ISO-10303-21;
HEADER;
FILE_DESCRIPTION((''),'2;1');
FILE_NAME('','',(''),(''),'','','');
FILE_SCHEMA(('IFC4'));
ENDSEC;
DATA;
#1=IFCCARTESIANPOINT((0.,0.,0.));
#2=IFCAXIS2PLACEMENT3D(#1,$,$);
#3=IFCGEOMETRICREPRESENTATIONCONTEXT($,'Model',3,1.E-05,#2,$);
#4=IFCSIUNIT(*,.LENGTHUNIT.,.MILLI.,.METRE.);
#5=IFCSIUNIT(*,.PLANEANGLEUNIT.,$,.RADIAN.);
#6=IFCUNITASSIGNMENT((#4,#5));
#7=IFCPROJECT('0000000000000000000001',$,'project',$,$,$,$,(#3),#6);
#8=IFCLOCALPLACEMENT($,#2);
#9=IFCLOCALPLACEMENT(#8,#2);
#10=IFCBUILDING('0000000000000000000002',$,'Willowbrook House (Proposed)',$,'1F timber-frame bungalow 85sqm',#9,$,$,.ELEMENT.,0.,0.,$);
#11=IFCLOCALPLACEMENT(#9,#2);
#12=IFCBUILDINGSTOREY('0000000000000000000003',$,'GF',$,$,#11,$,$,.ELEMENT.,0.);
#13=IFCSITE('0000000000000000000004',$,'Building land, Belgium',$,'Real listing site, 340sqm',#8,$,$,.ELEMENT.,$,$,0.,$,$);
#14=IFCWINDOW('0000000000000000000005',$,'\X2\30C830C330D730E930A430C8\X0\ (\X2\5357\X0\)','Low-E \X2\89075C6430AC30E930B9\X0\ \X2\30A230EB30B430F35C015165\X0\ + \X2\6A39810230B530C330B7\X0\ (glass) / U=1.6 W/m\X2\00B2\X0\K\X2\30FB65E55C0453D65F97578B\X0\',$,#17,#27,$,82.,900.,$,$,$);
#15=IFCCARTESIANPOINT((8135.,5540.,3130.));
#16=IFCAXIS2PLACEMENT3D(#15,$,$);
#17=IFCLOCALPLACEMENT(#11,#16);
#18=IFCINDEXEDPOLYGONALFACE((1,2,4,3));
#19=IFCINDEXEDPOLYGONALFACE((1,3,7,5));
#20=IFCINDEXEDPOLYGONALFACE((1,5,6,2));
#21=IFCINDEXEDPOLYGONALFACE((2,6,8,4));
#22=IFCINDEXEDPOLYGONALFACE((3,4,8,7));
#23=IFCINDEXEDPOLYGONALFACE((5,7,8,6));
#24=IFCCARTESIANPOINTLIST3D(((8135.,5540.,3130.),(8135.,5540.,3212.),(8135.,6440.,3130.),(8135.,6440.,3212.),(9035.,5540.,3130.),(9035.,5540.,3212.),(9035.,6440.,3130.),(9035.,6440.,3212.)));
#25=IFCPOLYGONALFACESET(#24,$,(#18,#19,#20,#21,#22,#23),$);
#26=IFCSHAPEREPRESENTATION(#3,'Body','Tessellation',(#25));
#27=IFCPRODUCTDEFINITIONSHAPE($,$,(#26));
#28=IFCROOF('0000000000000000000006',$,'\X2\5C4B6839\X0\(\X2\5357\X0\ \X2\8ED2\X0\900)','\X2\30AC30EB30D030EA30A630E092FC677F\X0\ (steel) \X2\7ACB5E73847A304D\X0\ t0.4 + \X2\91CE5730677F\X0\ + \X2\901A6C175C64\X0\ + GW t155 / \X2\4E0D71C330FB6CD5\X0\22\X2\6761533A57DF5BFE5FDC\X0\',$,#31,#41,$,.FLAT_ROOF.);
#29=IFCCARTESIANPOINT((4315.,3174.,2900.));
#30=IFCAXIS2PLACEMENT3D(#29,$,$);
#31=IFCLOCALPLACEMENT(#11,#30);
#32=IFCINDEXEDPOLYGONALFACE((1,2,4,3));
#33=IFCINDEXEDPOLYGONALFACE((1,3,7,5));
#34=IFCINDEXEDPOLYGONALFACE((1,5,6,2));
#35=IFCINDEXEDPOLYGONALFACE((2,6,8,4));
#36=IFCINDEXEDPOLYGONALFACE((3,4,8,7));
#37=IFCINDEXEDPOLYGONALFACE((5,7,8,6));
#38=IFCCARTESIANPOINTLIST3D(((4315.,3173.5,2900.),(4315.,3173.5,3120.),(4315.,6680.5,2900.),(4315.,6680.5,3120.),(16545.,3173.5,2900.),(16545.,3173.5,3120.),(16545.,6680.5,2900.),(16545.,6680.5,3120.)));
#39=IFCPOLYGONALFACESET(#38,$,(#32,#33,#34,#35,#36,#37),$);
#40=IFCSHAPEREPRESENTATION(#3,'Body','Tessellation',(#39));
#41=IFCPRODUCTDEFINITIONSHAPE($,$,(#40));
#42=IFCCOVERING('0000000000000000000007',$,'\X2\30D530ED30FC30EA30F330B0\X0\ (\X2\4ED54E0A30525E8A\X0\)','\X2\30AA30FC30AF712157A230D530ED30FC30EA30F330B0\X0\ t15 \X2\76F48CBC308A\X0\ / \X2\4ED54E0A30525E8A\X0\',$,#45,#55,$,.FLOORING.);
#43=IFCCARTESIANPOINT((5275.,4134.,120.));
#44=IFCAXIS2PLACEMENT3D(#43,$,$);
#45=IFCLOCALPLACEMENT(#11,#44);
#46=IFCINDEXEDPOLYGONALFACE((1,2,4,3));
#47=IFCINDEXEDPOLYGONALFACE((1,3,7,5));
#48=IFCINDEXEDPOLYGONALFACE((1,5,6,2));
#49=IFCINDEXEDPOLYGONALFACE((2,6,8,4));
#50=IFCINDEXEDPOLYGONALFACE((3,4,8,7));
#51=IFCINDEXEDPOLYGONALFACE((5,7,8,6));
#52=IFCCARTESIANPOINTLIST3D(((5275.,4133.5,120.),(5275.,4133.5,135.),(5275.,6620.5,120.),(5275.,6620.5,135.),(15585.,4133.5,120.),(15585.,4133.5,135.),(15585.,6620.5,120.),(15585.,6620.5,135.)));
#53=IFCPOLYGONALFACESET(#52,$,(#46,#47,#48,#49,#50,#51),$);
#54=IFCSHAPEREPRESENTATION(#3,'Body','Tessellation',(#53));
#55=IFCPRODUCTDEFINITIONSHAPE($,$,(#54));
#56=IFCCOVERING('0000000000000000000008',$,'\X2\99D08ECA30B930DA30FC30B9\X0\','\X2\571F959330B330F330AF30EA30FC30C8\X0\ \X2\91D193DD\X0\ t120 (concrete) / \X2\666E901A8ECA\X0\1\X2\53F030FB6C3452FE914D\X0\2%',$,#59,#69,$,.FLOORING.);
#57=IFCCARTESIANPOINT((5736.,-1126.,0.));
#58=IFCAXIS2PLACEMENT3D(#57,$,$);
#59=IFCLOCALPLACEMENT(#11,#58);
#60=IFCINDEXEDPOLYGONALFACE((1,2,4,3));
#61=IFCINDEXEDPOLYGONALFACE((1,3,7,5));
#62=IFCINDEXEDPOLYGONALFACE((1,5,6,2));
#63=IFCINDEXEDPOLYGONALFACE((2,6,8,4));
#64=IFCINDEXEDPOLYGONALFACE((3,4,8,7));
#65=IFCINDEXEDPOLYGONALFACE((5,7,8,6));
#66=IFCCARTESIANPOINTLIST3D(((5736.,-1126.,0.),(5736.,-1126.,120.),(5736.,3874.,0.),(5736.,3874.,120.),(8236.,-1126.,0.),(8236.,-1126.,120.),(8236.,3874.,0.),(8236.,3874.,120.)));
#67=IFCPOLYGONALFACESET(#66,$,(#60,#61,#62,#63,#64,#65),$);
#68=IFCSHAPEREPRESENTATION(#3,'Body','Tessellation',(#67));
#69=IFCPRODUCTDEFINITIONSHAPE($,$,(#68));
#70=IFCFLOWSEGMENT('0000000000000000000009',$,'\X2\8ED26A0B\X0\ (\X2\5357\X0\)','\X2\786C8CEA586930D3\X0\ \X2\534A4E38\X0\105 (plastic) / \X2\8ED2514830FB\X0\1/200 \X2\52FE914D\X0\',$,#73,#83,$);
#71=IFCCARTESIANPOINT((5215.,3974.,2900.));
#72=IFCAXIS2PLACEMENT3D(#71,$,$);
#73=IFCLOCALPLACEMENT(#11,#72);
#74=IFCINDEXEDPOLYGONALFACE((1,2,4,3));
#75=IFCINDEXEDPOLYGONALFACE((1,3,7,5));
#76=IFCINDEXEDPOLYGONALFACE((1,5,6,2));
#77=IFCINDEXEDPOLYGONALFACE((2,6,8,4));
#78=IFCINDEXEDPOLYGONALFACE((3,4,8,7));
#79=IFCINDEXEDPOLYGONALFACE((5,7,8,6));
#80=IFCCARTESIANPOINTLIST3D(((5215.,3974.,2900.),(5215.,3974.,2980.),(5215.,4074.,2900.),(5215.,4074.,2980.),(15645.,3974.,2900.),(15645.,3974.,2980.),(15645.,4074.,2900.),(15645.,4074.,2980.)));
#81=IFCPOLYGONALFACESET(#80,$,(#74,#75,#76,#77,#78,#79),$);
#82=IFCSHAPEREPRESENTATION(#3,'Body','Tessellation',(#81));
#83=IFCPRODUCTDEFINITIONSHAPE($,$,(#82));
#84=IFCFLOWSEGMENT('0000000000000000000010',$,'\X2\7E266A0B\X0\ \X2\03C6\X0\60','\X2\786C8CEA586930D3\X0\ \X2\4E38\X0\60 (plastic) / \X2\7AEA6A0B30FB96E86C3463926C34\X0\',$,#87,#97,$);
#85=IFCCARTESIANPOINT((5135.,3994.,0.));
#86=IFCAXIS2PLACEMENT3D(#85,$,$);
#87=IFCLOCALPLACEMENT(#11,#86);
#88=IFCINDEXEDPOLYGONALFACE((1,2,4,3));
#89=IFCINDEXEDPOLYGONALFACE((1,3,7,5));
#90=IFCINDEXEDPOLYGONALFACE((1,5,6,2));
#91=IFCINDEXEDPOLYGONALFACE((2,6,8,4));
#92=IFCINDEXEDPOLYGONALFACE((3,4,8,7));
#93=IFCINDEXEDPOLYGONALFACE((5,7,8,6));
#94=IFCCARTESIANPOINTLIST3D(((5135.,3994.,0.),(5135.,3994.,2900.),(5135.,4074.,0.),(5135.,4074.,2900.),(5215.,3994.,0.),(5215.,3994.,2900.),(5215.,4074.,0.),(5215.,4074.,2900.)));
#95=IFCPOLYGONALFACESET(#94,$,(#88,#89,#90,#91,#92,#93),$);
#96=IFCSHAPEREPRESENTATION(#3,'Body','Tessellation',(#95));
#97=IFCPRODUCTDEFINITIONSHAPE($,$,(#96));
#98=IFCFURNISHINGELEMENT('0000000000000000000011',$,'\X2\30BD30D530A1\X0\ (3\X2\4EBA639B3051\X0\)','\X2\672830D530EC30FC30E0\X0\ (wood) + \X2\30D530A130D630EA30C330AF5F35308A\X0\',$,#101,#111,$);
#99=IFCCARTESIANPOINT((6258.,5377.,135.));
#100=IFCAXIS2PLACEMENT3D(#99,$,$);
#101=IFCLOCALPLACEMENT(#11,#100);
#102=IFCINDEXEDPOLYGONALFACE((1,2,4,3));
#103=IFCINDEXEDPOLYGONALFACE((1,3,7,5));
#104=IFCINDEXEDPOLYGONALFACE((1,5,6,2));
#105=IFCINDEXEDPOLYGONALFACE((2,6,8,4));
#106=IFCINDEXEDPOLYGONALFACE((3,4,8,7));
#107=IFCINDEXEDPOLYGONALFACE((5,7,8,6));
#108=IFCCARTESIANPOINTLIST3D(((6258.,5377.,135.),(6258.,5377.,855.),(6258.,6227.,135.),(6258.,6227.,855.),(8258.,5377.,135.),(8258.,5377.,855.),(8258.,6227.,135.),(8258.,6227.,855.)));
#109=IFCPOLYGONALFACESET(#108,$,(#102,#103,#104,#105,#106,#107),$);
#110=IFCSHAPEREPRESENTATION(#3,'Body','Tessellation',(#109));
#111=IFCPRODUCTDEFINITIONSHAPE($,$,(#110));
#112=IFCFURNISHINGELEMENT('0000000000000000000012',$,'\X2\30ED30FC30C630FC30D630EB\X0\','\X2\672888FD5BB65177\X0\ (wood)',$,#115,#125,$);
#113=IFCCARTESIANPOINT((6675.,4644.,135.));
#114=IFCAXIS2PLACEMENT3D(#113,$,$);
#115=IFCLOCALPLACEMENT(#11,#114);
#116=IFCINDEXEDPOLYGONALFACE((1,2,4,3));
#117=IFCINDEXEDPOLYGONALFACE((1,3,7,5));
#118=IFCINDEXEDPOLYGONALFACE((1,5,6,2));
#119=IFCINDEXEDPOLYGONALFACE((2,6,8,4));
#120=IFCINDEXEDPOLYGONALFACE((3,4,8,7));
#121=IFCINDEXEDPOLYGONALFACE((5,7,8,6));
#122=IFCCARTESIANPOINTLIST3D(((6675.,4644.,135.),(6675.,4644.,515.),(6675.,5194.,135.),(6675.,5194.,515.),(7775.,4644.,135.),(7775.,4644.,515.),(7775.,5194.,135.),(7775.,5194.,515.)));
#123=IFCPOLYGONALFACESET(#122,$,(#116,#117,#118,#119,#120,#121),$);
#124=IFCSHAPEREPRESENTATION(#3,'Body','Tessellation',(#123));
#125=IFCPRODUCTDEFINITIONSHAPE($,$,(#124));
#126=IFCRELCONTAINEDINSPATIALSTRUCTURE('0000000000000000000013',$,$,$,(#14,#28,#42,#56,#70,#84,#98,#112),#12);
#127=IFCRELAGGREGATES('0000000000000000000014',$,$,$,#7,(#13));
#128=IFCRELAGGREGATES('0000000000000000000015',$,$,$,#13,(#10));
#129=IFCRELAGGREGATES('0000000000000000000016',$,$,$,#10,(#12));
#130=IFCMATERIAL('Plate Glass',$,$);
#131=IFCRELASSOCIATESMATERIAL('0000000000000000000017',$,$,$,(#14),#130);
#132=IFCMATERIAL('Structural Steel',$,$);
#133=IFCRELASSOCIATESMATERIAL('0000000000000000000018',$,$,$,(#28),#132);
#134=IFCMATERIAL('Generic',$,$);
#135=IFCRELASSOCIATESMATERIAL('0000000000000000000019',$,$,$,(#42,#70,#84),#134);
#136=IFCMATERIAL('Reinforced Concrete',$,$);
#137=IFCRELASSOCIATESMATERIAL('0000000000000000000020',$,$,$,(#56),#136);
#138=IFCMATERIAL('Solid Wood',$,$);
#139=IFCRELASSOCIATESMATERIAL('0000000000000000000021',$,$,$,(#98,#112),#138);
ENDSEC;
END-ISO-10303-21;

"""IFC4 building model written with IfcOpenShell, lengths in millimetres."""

from ifc_helpers import new_model, si_unit, frame, frame_2d, origin, place, context, project, spatial, rectangle, extrude, material, element, save


model = new_model("IFC4")

# Units and contexts
model_context = context("Model", 3, precision=1e-05, world=origin())
ifc_project = project(units=[si_unit("LENGTHUNIT", "METRE", prefix="MILLI"), si_unit("PLANEANGLEUNIT", "RADIAN")], contexts=[model_context])

# Site, building, storey
site_placement = place(None, origin())
site = spatial("IfcSite", under=ifc_project, at=site_placement, Name="Building land, Belgium", ObjectType="Real listing site, 340sqm", CompositionType="ELEMENT", RefElevation=0.0)
building_placement = place(site_placement, origin())
building = spatial("IfcBuilding", under=site, at=building_placement, Name="Willowbrook House (Proposed)", ObjectType="1F timber-frame bungalow 85sqm", CompositionType="ELEMENT", ElevationOfRefHeight=0.0, ElevationOfTerrain=0.0)
storey_placement = place(building_placement, origin())
storey = spatial("IfcBuildingStorey", under=building, at=storey_placement, Name="GF", CompositionType="ELEMENT", Elevation=0.0)

# Shared definitions
ifc_material_1 = material(Name="Solid Wood")

# Shared definitions
ifc_material_2 = material(Name="Reinforced Concrete")

# Shared definitions
ifc_material_3 = material(Name="Plate Glass")

# Window
window_1_placement = place(storey_placement, frame((8135.0, 5540.0, 3130.0)))
element("IfcWindow", 1, at=window_1_placement, inside=storey, material=ifc_material_3, Name="トップライト (南)", Description="Low-E 複層ガラス アルゴン封入 + 樹脂サッシ (glass) / U=1.6 W/m²K・日射取得型", OverallHeight=82.0, OverallWidth=900.0, context=model_context, shape_type="SweptSolid", body=[
    extrude(rectangle(XDim=900.0, YDim=900.0, at=frame_2d((450.0, 450.0))), frame((8135.0, 5540.0, 3130.0)), (0.0, 0.0, 1.0), 82.0),
])

# Roof
ifc_material_4 = material(Name="Structural Steel")
roof_1_placement = place(storey_placement, frame((4315.0, 3174.0, 2900.0)))
element("IfcRoof", 2, at=roof_1_placement, inside=storey, material=ifc_material_4, Name="屋根(南 軒900)", Description="ガルバリウム鋼板 (steel) 立平葺き t0.4 + 野地板 + 通気層 + GW t155 / 不燃・法22条区域対応", PredefinedType="FLAT_ROOF", context=model_context, shape_type="SweptSolid", body=[
    extrude(rectangle(XDim=12230.0, YDim=3507.0, at=frame_2d((6115.0, 1753.0))), frame((4315.0, 3174.0, 2900.0)), (0.0, 0.0, 1.0), 220.0),
])

# Coverings
ifc_material_5 = material(Name="Generic")
covering_1_placement = place(storey_placement, frame((5275.0, 4134.0, 120.0)))
element("IfcCovering", 3, at=covering_1_placement, inside=storey, material=ifc_material_5, Name="フローリング (仕上げ床)", Description="オーク無垢フローリング t15 直貼り / 仕上げ床", PredefinedType="FLOORING", context=model_context, shape_type="SweptSolid", body=[
    extrude(rectangle(XDim=10310.0, YDim=2487.0, at=frame_2d((5155.0, 1243.0))), frame((5275.0, 4134.0, 120.0)), (0.0, 0.0, 1.0), 15.0),
])
covering_2_placement = place(storey_placement, frame((5736.0, -1126.0, 0.0)))
element("IfcCovering", 4, at=covering_2_placement, inside=storey, material=ifc_material_2, Name="駐車スペース", Description="土間コンクリート 金鏝 t120 (concrete) / 普通車1台・水勾配2%", PredefinedType="FLOORING", context=model_context, shape_type="SweptSolid", body=[
    extrude(rectangle(XDim=2500.0, YDim=5000.0, at=frame_2d((1250.0, 2500.0))), frame((5736.0, -1126.0, 0.0)), (0.0, 0.0, 1.0), 120.0),
])

# Flow segments
flow_segment_1_placement = place(storey_placement, frame((5215.0, 3974.0, 2900.0)))
element("IfcFlowSegment", 5, at=flow_segment_1_placement, inside=storey, material=ifc_material_5, Name="軒樋 (南)", Description="硬質塩ビ 半丸105 (plastic) / 軒先・1/200 勾配", context=model_context, shape_type="SweptSolid", body=[
    extrude(rectangle(XDim=10430.0, YDim=100.0, at=frame_2d((5215.0, 50.0))), frame((5215.0, 3974.0, 2900.0)), (0.0, 0.0, 1.0), 80.0),
])
flow_segment_2_placement = place(storey_placement, frame((5135.0, 3994.0, 0.0)))
element("IfcFlowSegment", 6, at=flow_segment_2_placement, inside=storey, material=ifc_material_5, Name="縦樋 φ60", Description="硬質塩ビ 丸60 (plastic) / 竪樋・雨水排水", context=model_context, shape_type="SweptSolid", body=[
    extrude(rectangle(XDim=80.0, YDim=80.0, at=frame_2d((40.0, 40.0))), frame((5135.0, 3994.0, 0.0)), (0.0, 0.0, 1.0), 2900.0),
])

# Furnishing elements
furnishing_1_placement = place(storey_placement, frame((6258.0, 5377.0, 135.0)))
element("IfcFurnishingElement", 7, at=furnishing_1_placement, inside=storey, material=ifc_material_1, Name="ソファ (3人掛け)", Description="木フレーム (wood) + ファブリック張り", context=model_context, shape_type="SweptSolid", body=[
    extrude(rectangle(XDim=2000.0, YDim=850.0, at=frame_2d((1000.0, 425.0))), frame((6258.0, 5377.0, 135.0)), (0.0, 0.0, 1.0), 720.0),
])
furnishing_2_placement = place(storey_placement, frame((6675.0, 4644.0, 135.0)))
element("IfcFurnishingElement", 8, at=furnishing_2_placement, inside=storey, material=ifc_material_1, Name="ローテーブル", Description="木製家具 (wood)", context=model_context, shape_type="SweptSolid", body=[
    extrude(rectangle(XDim=1100.0, YDim=550.0, at=frame_2d((550.0, 275.0))), frame((6675.0, 4644.0, 135.0)), (0.0, 0.0, 1.0), 380.0),
])

save(model, "model.ifc")
